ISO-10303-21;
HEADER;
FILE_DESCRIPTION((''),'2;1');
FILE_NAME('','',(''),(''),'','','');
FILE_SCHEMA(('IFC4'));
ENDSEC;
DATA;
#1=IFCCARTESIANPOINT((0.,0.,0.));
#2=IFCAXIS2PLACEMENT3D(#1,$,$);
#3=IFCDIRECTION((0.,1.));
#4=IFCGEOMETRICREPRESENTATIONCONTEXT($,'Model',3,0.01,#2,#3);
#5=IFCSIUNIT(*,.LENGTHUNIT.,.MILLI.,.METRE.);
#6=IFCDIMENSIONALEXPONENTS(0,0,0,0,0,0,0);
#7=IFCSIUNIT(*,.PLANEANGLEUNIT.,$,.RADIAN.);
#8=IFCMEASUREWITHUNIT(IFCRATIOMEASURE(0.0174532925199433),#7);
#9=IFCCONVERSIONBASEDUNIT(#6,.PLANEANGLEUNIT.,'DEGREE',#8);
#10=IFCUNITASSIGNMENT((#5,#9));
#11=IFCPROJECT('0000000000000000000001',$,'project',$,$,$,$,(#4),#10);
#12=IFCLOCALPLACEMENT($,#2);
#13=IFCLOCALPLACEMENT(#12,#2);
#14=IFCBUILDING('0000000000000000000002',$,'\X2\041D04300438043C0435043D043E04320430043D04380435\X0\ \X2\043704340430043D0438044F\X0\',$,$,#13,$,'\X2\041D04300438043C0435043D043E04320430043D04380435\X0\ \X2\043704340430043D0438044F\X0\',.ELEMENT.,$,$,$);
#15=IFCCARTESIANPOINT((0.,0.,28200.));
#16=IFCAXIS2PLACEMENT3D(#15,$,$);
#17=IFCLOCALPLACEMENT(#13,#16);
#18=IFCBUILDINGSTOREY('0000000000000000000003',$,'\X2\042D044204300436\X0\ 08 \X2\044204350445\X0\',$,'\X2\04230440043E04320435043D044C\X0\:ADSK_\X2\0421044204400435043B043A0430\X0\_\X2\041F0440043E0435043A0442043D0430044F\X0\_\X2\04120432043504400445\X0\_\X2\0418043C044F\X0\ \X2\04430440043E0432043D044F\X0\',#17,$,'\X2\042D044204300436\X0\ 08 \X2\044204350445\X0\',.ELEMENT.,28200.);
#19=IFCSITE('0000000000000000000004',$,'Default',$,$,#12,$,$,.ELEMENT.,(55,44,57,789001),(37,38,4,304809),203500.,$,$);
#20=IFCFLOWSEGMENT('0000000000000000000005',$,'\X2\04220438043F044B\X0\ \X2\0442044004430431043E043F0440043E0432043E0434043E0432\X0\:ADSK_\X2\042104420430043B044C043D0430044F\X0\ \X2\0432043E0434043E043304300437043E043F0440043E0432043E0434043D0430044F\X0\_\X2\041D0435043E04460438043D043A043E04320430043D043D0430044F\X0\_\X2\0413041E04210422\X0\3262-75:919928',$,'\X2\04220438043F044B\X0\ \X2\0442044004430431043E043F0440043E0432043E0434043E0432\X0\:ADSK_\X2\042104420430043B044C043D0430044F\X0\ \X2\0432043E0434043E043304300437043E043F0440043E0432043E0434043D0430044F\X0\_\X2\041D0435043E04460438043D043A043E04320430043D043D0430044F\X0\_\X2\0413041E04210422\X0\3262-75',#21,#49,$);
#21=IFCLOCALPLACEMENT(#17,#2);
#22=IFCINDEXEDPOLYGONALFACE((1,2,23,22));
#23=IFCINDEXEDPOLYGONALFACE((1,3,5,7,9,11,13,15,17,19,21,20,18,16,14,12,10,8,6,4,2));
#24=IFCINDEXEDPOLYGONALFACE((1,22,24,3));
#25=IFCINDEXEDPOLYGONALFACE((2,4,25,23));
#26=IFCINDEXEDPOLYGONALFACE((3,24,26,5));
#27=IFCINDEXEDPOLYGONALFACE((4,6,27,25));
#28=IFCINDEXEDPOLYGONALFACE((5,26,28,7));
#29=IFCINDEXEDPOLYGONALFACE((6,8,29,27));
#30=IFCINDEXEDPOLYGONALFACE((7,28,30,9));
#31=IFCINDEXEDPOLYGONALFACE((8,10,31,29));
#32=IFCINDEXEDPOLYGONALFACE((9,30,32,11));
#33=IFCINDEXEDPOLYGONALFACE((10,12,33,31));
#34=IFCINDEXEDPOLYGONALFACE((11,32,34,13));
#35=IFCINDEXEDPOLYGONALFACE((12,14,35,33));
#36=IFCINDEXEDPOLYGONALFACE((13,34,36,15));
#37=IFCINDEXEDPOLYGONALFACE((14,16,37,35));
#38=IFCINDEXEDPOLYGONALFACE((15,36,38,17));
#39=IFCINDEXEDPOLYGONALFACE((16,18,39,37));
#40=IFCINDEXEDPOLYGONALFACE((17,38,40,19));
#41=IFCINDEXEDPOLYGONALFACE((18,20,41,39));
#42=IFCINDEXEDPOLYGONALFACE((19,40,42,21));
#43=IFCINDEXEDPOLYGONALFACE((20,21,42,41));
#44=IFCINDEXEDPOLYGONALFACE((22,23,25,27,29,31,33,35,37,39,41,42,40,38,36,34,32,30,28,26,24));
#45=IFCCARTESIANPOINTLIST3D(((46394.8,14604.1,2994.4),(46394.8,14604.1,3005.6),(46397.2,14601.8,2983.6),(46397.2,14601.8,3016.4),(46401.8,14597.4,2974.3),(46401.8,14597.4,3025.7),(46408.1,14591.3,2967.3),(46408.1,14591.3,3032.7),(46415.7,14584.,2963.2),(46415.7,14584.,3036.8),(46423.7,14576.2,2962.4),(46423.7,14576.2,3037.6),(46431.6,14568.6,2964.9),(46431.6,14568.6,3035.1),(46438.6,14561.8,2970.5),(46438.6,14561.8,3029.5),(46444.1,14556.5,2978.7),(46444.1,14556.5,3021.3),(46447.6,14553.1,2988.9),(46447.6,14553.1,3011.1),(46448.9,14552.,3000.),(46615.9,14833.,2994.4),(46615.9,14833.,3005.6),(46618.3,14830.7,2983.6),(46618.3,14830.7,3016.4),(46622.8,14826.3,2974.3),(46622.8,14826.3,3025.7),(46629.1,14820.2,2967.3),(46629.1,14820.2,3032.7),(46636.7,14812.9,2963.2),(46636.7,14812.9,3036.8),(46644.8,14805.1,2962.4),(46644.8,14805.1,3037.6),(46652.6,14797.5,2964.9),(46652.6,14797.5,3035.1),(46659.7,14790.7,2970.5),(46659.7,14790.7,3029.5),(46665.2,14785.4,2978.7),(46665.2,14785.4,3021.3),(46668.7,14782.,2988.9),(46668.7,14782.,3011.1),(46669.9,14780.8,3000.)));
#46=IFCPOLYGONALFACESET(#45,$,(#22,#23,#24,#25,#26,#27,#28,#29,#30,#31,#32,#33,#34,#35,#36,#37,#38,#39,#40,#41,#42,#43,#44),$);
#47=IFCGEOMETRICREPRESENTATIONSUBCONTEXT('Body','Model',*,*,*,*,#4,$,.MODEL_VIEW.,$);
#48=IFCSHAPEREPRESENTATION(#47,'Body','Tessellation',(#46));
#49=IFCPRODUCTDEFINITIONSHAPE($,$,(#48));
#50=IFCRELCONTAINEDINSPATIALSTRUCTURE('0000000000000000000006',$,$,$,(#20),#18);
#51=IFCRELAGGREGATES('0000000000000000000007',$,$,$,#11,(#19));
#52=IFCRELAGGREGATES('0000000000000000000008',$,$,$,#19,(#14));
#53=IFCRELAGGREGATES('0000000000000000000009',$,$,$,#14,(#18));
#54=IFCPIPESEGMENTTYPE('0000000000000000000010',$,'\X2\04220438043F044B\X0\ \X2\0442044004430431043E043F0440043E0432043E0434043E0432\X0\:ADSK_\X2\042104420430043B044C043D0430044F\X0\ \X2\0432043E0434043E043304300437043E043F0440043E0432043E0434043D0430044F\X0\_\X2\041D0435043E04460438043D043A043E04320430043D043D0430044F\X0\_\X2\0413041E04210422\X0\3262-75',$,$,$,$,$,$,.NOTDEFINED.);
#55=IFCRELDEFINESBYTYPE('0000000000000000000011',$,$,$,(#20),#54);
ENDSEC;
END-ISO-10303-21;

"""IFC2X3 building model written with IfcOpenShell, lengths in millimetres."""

from ifc_helpers import new_model, entity, si_unit, converted_unit, direction, frame, origin, origin_2d_with_axis, place, context, subcontext, project, spatial, circle, extrude, type_object, element, save


model = new_model("IFC2X3")

# Units and contexts
model_context = context("Model", 3, precision=0.01, world=origin(), true_north=direction((0.0, 1.0)))
body_context = subcontext(model_context, "Body", "Model", "MODEL_VIEW")
ifc_project = project(units=[si_unit("LENGTHUNIT", "METRE", prefix="MILLI"), converted_unit("PLANEANGLEUNIT", "DEGREE", entity("IfcRatioMeasure", 0.0174532925199433), si_unit("PLANEANGLEUNIT", "RADIAN"), dimensions=[0, 0, 0, 0, 0, 0, 0])], contexts=[model_context])

# Site, building, storey
site_placement = place(None, origin())
site = spatial("IfcSite", under=ifc_project, at=site_placement, Name="Default", CompositionType="ELEMENT", RefLatitude=(55, 44, 57, 789001), RefLongitude=(37, 38, 4, 304809), RefElevation=203500.0)
building_placement = place(site_placement, origin())
building = spatial("IfcBuilding", under=site, at=building_placement, Name="Наименование здания", LongName="Наименование здания", CompositionType="ELEMENT")
storey_placement = place(building_placement, frame((0.0, 0.0, 28200.0)))
storey = spatial("IfcBuildingStorey", under=building, at=storey_placement, Name="Этаж 08 тех", ObjectType="Уровень:ADSK_Стрелка_Проектная_Вверх_Имя уровня", LongName="Этаж 08 тех", CompositionType="ELEMENT", Elevation=28200.0)

# Flow segment
pipe_segment_type = type_object("IfcPipeSegmentType", Name="Типы трубопроводов:ADSK_Стальная водогазопроводная_Неоцинкованная_ГОСТ3262-75", PredefinedType="NOTDEFINED")
flow_segment_1_placement = place(storey_placement, frame((46392.9, 14550.4, 2960.7)))
element("IfcFlowSegment", 1, at=flow_segment_1_placement, inside=storey, type_object=pipe_segment_type, Name="Типы трубопроводов:ADSK_Стальная водогазопроводная_Неоцинкованная_ГОСТ3262-75:919928", ObjectType="Типы трубопроводов:ADSK_Стальная водогазопроводная_Неоцинкованная_ГОСТ3262-75", context=body_context, shape_type="SweptSolid", body=[
    extrude(circle(Radius=37.8, at=origin_2d_with_axis()), frame((28.8, 27.8, 39.4), z_axis=(0.694658, 0.71934, 0.0), x_axis=(0.71934, -0.694658, 0.0)), (0.0, 0.0, 1.0), 318.2),
])

save(model, "model.ifc")
